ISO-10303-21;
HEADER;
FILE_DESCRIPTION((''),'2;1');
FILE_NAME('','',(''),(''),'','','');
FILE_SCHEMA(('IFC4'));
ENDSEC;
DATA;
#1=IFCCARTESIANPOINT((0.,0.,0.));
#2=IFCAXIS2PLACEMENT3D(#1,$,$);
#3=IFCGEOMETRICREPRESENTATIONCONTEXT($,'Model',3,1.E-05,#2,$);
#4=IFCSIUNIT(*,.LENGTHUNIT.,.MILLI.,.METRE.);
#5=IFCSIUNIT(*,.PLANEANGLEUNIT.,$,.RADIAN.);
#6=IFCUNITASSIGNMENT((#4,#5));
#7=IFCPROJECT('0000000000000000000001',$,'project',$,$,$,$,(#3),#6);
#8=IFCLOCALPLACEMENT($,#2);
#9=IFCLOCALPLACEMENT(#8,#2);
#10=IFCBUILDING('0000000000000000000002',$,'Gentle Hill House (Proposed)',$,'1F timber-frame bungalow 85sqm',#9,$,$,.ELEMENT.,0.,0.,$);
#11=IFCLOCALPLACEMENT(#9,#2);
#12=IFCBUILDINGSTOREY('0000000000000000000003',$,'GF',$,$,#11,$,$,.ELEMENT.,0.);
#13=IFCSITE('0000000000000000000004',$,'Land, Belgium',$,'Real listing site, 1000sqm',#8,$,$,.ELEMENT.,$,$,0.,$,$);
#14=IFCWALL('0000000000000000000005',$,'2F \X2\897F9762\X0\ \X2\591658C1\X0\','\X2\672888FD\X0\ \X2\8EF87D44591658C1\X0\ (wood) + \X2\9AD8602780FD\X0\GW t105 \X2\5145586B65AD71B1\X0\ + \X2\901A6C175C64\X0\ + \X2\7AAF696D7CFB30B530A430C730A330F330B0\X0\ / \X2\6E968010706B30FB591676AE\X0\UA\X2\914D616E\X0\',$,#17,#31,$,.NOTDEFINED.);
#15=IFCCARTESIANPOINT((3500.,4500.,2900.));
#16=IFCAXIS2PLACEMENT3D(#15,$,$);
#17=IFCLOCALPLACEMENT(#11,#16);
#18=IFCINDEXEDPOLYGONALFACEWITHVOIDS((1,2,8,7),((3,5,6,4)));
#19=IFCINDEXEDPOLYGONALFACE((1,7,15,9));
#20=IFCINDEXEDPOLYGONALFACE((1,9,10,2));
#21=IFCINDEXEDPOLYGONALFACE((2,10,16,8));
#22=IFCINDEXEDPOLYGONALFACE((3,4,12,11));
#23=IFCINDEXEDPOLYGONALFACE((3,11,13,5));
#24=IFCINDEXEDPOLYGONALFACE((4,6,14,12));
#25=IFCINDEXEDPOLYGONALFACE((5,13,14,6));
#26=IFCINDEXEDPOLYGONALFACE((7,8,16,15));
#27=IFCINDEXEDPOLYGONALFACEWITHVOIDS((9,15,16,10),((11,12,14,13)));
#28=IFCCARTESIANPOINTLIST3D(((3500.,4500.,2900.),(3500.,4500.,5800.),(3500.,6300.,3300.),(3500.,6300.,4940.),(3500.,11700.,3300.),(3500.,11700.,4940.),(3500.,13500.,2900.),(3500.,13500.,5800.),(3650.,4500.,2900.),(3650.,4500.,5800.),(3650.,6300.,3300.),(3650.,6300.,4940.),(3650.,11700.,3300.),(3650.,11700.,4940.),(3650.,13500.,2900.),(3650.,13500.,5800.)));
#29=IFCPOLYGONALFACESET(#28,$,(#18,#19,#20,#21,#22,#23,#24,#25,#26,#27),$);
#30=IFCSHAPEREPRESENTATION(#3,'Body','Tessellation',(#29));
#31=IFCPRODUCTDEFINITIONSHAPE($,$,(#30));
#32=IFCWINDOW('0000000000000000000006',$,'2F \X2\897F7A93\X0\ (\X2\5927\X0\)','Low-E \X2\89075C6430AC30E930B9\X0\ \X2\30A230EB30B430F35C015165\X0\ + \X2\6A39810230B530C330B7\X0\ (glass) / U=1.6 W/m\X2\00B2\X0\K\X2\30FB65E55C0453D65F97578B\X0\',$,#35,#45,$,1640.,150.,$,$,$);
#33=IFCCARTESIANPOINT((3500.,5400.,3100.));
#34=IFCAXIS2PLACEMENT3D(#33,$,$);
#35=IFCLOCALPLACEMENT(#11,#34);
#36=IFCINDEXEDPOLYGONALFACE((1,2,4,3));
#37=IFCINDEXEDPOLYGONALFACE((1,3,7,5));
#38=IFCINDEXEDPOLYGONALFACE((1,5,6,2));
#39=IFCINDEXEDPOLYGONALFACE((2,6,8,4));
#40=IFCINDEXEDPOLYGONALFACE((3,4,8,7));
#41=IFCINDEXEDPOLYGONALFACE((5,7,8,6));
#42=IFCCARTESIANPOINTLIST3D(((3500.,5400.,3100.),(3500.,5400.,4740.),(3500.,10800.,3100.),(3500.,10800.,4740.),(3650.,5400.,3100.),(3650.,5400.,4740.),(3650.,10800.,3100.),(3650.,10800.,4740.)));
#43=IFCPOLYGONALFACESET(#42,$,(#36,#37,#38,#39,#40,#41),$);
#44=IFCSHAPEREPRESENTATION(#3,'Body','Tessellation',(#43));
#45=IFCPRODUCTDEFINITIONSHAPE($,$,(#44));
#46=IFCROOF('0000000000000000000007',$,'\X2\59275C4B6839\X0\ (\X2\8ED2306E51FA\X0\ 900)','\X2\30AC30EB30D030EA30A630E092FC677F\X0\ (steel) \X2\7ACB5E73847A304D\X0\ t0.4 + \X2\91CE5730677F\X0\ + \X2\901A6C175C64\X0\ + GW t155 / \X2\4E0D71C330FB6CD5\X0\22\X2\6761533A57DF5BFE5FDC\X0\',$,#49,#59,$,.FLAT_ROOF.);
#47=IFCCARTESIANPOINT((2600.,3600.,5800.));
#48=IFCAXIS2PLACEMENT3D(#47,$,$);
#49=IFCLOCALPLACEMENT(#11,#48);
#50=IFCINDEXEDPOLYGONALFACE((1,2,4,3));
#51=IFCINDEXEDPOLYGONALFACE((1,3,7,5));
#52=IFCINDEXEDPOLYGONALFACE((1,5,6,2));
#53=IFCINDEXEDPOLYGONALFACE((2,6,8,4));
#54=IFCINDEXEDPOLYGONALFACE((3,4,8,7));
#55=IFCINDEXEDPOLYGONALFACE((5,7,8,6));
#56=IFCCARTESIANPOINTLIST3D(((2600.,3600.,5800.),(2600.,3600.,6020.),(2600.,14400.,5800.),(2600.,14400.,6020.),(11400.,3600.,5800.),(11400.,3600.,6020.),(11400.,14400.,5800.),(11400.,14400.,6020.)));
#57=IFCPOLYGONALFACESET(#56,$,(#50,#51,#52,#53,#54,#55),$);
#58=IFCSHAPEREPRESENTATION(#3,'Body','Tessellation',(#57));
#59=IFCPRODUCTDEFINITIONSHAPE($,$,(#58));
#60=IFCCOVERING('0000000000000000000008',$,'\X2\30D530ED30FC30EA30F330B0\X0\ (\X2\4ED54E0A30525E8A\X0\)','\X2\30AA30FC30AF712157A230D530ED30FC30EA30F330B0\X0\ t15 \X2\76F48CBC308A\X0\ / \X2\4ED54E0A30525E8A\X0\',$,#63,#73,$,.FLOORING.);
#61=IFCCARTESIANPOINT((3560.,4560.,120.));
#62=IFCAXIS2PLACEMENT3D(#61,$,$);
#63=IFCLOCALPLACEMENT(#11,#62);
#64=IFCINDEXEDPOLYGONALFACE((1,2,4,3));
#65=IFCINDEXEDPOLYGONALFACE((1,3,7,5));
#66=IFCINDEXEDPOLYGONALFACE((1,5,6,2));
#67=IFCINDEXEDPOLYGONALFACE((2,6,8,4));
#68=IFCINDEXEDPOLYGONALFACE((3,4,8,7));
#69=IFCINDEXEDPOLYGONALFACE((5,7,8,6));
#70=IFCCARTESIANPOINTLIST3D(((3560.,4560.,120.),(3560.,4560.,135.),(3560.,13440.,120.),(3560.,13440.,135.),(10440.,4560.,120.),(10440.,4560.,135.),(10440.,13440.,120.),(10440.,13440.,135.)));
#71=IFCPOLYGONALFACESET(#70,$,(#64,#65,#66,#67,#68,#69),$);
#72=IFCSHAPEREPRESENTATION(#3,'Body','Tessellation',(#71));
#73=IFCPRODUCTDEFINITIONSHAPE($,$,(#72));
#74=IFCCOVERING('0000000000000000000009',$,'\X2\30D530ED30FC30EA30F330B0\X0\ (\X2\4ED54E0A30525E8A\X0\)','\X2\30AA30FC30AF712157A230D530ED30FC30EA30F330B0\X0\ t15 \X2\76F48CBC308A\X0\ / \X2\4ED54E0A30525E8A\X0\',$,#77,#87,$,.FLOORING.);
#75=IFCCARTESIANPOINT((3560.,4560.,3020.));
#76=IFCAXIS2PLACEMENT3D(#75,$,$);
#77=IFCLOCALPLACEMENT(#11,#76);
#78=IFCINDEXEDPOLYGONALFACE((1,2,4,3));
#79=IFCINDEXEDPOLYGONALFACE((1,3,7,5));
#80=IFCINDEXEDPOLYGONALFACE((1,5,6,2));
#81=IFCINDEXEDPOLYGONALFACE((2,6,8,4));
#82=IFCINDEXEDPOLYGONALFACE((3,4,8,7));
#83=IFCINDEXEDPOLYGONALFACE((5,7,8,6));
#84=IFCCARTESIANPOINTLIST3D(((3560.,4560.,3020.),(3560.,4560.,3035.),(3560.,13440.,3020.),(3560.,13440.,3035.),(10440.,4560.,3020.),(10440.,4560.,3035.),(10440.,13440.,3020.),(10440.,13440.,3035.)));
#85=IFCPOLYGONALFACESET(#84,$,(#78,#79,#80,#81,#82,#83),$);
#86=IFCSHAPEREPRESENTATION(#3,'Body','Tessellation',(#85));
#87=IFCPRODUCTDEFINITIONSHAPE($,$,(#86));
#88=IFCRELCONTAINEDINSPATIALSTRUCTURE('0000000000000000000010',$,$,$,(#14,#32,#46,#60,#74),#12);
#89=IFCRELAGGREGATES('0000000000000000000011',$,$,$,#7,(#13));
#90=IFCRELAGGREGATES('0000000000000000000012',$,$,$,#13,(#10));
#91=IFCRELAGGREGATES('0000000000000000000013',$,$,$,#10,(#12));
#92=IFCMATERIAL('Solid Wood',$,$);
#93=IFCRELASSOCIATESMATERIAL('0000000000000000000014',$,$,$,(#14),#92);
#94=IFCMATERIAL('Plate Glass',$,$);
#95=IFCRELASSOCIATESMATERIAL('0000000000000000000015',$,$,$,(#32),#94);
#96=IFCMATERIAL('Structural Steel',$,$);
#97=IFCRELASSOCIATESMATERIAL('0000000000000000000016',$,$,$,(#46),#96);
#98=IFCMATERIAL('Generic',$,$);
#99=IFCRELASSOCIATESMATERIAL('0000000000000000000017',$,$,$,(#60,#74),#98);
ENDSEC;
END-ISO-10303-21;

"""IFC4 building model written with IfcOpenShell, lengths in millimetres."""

from ifc_helpers import new_model, si_unit, frame, frame_2d, origin, place, context, project, spatial, rectangle, extrude, material, element, fill, save


model = new_model("IFC4")

# Units and contexts
model_context = context("Model", 3, precision=1e-05, world=origin())
ifc_project = project(units=[si_unit("LENGTHUNIT", "METRE", prefix="MILLI"), si_unit("PLANEANGLEUNIT", "RADIAN")], contexts=[model_context])

# Site, building, storey
site_placement = place(None, origin())
site = spatial("IfcSite", under=ifc_project, at=site_placement, Name="Land, Belgium", ObjectType="Real listing site, 1000sqm", CompositionType="ELEMENT", RefElevation=0.0)
building_placement = place(site_placement, origin())
building = spatial("IfcBuilding", under=site, at=building_placement, Name="Gentle Hill House (Proposed)", ObjectType="1F timber-frame bungalow 85sqm", CompositionType="ELEMENT", ElevationOfRefHeight=0.0, ElevationOfTerrain=0.0)
storey_placement = place(building_placement, origin())
storey = spatial("IfcBuildingStorey", under=building, at=storey_placement, Name="GF", CompositionType="ELEMENT", Elevation=0.0)

# Shared definitions
ifc_material_1 = material(Name="Solid Wood")
ifc_material_2 = material(Name="Generic")

# Shared definitions
ifc_material_3 = material(Name="Plate Glass")

# Wall, opening, window
wall_1_placement = place(storey_placement, frame((3500.0, 4500.0, 2900.0)))
wall_1 = element("IfcWall", 1, at=wall_1_placement, inside=storey, material=ifc_material_1, Name="2F 西面 外壁", Description="木製 軸組外壁 (wood) + 高性能GW t105 充填断熱 + 通気層 + 窯業系サイディング / 準耐火・外皮UA配慮", PredefinedType="NOTDEFINED", context=model_context, shape_type="SweptSolid", body=[
    extrude(rectangle(XDim=150.0, YDim=9000.0, at=frame_2d((75.0, 4500.0))), frame((3500.0, 4500.0, 2900.0)), (0.0, 0.0, 1.0), 2900.0),
])
opening_1_placement = place(storey_placement, frame((3500.0, 5400.0, 3100.0)))
opening_1 = element("IfcOpeningElement", 2, at=opening_1_placement, cuts=wall_1, PredefinedType="NOTDEFINED", context=model_context, shape_type="SweptSolid", body=[
    extrude(rectangle(XDim=150.0, YDim=5400.0, at=frame_2d((75.0, 2700.0))), frame((3500.0, 5400.0, 3100.0)), (0.0, 0.0, 1.0), 1640.0),
])
window_1_placement = place(storey_placement, frame((3500.0, 5400.0, 3100.0)))
window_1 = element("IfcWindow", 3, at=window_1_placement, inside=storey, material=ifc_material_3, Name="2F 西窓 (大)", Description="Low-E 複層ガラス アルゴン封入 + 樹脂サッシ (glass) / U=1.6 W/m²K・日射取得型", OverallHeight=1640.0, OverallWidth=150.0, context=model_context, shape_type="SweptSolid", body=[
    extrude(rectangle(XDim=150.0, YDim=5400.0, at=frame_2d((75.0, 2700.0))), frame((3500.0, 5400.0, 3100.0)), (0.0, 0.0, 1.0), 1640.0),
])
fill(opening_1, window_1)

# Roof
ifc_material_4 = material(Name="Structural Steel")
roof_placement = place(storey_placement, frame((2600.0, 3600.0, 5800.0)))
element("IfcRoof", 4, at=roof_placement, inside=storey, material=ifc_material_4, Name="大屋根 (軒の出 900)", Description="ガルバリウム鋼板 (steel) 立平葺き t0.4 + 野地板 + 通気層 + GW t155 / 不燃・法22条区域対応", PredefinedType="FLAT_ROOF", context=model_context, shape_type="SweptSolid", body=[
    extrude(rectangle(XDim=8800.0, YDim=10800.0, at=frame_2d((4400.0, 5400.0))), frame((2600.0, 3600.0, 5800.0)), (0.0, 0.0, 1.0), 220.0),
])

# Coverings
covering_1_placement = place(storey_placement, frame((3560.0, 4560.0, 120.0)))
element("IfcCovering", 5, at=covering_1_placement, inside=storey, material=ifc_material_2, Name="フローリング (仕上げ床)", Description="オーク無垢フローリング t15 直貼り / 仕上げ床", PredefinedType="FLOORING", context=model_context, shape_type="SweptSolid", body=[
    extrude(rectangle(XDim=6880.0, YDim=8880.0, at=frame_2d((3440.0, 4440.0))), frame((3560.0, 4560.0, 120.0)), (0.0, 0.0, 1.0), 15.0),
])
covering_2_placement = place(storey_placement, frame((3560.0, 4560.0, 3020.0)))
element("IfcCovering", 6, at=covering_2_placement, inside=storey, material=ifc_material_2, Name="フローリング (仕上げ床)", Description="オーク無垢フローリング t15 直貼り / 仕上げ床", PredefinedType="FLOORING", context=model_context, shape_type="SweptSolid", body=[
    extrude(rectangle(XDim=6880.0, YDim=8880.0, at=frame_2d((3440.0, 4440.0))), frame((3560.0, 4560.0, 3020.0)), (0.0, 0.0, 1.0), 15.0),
])

save(model, "model.ifc")
